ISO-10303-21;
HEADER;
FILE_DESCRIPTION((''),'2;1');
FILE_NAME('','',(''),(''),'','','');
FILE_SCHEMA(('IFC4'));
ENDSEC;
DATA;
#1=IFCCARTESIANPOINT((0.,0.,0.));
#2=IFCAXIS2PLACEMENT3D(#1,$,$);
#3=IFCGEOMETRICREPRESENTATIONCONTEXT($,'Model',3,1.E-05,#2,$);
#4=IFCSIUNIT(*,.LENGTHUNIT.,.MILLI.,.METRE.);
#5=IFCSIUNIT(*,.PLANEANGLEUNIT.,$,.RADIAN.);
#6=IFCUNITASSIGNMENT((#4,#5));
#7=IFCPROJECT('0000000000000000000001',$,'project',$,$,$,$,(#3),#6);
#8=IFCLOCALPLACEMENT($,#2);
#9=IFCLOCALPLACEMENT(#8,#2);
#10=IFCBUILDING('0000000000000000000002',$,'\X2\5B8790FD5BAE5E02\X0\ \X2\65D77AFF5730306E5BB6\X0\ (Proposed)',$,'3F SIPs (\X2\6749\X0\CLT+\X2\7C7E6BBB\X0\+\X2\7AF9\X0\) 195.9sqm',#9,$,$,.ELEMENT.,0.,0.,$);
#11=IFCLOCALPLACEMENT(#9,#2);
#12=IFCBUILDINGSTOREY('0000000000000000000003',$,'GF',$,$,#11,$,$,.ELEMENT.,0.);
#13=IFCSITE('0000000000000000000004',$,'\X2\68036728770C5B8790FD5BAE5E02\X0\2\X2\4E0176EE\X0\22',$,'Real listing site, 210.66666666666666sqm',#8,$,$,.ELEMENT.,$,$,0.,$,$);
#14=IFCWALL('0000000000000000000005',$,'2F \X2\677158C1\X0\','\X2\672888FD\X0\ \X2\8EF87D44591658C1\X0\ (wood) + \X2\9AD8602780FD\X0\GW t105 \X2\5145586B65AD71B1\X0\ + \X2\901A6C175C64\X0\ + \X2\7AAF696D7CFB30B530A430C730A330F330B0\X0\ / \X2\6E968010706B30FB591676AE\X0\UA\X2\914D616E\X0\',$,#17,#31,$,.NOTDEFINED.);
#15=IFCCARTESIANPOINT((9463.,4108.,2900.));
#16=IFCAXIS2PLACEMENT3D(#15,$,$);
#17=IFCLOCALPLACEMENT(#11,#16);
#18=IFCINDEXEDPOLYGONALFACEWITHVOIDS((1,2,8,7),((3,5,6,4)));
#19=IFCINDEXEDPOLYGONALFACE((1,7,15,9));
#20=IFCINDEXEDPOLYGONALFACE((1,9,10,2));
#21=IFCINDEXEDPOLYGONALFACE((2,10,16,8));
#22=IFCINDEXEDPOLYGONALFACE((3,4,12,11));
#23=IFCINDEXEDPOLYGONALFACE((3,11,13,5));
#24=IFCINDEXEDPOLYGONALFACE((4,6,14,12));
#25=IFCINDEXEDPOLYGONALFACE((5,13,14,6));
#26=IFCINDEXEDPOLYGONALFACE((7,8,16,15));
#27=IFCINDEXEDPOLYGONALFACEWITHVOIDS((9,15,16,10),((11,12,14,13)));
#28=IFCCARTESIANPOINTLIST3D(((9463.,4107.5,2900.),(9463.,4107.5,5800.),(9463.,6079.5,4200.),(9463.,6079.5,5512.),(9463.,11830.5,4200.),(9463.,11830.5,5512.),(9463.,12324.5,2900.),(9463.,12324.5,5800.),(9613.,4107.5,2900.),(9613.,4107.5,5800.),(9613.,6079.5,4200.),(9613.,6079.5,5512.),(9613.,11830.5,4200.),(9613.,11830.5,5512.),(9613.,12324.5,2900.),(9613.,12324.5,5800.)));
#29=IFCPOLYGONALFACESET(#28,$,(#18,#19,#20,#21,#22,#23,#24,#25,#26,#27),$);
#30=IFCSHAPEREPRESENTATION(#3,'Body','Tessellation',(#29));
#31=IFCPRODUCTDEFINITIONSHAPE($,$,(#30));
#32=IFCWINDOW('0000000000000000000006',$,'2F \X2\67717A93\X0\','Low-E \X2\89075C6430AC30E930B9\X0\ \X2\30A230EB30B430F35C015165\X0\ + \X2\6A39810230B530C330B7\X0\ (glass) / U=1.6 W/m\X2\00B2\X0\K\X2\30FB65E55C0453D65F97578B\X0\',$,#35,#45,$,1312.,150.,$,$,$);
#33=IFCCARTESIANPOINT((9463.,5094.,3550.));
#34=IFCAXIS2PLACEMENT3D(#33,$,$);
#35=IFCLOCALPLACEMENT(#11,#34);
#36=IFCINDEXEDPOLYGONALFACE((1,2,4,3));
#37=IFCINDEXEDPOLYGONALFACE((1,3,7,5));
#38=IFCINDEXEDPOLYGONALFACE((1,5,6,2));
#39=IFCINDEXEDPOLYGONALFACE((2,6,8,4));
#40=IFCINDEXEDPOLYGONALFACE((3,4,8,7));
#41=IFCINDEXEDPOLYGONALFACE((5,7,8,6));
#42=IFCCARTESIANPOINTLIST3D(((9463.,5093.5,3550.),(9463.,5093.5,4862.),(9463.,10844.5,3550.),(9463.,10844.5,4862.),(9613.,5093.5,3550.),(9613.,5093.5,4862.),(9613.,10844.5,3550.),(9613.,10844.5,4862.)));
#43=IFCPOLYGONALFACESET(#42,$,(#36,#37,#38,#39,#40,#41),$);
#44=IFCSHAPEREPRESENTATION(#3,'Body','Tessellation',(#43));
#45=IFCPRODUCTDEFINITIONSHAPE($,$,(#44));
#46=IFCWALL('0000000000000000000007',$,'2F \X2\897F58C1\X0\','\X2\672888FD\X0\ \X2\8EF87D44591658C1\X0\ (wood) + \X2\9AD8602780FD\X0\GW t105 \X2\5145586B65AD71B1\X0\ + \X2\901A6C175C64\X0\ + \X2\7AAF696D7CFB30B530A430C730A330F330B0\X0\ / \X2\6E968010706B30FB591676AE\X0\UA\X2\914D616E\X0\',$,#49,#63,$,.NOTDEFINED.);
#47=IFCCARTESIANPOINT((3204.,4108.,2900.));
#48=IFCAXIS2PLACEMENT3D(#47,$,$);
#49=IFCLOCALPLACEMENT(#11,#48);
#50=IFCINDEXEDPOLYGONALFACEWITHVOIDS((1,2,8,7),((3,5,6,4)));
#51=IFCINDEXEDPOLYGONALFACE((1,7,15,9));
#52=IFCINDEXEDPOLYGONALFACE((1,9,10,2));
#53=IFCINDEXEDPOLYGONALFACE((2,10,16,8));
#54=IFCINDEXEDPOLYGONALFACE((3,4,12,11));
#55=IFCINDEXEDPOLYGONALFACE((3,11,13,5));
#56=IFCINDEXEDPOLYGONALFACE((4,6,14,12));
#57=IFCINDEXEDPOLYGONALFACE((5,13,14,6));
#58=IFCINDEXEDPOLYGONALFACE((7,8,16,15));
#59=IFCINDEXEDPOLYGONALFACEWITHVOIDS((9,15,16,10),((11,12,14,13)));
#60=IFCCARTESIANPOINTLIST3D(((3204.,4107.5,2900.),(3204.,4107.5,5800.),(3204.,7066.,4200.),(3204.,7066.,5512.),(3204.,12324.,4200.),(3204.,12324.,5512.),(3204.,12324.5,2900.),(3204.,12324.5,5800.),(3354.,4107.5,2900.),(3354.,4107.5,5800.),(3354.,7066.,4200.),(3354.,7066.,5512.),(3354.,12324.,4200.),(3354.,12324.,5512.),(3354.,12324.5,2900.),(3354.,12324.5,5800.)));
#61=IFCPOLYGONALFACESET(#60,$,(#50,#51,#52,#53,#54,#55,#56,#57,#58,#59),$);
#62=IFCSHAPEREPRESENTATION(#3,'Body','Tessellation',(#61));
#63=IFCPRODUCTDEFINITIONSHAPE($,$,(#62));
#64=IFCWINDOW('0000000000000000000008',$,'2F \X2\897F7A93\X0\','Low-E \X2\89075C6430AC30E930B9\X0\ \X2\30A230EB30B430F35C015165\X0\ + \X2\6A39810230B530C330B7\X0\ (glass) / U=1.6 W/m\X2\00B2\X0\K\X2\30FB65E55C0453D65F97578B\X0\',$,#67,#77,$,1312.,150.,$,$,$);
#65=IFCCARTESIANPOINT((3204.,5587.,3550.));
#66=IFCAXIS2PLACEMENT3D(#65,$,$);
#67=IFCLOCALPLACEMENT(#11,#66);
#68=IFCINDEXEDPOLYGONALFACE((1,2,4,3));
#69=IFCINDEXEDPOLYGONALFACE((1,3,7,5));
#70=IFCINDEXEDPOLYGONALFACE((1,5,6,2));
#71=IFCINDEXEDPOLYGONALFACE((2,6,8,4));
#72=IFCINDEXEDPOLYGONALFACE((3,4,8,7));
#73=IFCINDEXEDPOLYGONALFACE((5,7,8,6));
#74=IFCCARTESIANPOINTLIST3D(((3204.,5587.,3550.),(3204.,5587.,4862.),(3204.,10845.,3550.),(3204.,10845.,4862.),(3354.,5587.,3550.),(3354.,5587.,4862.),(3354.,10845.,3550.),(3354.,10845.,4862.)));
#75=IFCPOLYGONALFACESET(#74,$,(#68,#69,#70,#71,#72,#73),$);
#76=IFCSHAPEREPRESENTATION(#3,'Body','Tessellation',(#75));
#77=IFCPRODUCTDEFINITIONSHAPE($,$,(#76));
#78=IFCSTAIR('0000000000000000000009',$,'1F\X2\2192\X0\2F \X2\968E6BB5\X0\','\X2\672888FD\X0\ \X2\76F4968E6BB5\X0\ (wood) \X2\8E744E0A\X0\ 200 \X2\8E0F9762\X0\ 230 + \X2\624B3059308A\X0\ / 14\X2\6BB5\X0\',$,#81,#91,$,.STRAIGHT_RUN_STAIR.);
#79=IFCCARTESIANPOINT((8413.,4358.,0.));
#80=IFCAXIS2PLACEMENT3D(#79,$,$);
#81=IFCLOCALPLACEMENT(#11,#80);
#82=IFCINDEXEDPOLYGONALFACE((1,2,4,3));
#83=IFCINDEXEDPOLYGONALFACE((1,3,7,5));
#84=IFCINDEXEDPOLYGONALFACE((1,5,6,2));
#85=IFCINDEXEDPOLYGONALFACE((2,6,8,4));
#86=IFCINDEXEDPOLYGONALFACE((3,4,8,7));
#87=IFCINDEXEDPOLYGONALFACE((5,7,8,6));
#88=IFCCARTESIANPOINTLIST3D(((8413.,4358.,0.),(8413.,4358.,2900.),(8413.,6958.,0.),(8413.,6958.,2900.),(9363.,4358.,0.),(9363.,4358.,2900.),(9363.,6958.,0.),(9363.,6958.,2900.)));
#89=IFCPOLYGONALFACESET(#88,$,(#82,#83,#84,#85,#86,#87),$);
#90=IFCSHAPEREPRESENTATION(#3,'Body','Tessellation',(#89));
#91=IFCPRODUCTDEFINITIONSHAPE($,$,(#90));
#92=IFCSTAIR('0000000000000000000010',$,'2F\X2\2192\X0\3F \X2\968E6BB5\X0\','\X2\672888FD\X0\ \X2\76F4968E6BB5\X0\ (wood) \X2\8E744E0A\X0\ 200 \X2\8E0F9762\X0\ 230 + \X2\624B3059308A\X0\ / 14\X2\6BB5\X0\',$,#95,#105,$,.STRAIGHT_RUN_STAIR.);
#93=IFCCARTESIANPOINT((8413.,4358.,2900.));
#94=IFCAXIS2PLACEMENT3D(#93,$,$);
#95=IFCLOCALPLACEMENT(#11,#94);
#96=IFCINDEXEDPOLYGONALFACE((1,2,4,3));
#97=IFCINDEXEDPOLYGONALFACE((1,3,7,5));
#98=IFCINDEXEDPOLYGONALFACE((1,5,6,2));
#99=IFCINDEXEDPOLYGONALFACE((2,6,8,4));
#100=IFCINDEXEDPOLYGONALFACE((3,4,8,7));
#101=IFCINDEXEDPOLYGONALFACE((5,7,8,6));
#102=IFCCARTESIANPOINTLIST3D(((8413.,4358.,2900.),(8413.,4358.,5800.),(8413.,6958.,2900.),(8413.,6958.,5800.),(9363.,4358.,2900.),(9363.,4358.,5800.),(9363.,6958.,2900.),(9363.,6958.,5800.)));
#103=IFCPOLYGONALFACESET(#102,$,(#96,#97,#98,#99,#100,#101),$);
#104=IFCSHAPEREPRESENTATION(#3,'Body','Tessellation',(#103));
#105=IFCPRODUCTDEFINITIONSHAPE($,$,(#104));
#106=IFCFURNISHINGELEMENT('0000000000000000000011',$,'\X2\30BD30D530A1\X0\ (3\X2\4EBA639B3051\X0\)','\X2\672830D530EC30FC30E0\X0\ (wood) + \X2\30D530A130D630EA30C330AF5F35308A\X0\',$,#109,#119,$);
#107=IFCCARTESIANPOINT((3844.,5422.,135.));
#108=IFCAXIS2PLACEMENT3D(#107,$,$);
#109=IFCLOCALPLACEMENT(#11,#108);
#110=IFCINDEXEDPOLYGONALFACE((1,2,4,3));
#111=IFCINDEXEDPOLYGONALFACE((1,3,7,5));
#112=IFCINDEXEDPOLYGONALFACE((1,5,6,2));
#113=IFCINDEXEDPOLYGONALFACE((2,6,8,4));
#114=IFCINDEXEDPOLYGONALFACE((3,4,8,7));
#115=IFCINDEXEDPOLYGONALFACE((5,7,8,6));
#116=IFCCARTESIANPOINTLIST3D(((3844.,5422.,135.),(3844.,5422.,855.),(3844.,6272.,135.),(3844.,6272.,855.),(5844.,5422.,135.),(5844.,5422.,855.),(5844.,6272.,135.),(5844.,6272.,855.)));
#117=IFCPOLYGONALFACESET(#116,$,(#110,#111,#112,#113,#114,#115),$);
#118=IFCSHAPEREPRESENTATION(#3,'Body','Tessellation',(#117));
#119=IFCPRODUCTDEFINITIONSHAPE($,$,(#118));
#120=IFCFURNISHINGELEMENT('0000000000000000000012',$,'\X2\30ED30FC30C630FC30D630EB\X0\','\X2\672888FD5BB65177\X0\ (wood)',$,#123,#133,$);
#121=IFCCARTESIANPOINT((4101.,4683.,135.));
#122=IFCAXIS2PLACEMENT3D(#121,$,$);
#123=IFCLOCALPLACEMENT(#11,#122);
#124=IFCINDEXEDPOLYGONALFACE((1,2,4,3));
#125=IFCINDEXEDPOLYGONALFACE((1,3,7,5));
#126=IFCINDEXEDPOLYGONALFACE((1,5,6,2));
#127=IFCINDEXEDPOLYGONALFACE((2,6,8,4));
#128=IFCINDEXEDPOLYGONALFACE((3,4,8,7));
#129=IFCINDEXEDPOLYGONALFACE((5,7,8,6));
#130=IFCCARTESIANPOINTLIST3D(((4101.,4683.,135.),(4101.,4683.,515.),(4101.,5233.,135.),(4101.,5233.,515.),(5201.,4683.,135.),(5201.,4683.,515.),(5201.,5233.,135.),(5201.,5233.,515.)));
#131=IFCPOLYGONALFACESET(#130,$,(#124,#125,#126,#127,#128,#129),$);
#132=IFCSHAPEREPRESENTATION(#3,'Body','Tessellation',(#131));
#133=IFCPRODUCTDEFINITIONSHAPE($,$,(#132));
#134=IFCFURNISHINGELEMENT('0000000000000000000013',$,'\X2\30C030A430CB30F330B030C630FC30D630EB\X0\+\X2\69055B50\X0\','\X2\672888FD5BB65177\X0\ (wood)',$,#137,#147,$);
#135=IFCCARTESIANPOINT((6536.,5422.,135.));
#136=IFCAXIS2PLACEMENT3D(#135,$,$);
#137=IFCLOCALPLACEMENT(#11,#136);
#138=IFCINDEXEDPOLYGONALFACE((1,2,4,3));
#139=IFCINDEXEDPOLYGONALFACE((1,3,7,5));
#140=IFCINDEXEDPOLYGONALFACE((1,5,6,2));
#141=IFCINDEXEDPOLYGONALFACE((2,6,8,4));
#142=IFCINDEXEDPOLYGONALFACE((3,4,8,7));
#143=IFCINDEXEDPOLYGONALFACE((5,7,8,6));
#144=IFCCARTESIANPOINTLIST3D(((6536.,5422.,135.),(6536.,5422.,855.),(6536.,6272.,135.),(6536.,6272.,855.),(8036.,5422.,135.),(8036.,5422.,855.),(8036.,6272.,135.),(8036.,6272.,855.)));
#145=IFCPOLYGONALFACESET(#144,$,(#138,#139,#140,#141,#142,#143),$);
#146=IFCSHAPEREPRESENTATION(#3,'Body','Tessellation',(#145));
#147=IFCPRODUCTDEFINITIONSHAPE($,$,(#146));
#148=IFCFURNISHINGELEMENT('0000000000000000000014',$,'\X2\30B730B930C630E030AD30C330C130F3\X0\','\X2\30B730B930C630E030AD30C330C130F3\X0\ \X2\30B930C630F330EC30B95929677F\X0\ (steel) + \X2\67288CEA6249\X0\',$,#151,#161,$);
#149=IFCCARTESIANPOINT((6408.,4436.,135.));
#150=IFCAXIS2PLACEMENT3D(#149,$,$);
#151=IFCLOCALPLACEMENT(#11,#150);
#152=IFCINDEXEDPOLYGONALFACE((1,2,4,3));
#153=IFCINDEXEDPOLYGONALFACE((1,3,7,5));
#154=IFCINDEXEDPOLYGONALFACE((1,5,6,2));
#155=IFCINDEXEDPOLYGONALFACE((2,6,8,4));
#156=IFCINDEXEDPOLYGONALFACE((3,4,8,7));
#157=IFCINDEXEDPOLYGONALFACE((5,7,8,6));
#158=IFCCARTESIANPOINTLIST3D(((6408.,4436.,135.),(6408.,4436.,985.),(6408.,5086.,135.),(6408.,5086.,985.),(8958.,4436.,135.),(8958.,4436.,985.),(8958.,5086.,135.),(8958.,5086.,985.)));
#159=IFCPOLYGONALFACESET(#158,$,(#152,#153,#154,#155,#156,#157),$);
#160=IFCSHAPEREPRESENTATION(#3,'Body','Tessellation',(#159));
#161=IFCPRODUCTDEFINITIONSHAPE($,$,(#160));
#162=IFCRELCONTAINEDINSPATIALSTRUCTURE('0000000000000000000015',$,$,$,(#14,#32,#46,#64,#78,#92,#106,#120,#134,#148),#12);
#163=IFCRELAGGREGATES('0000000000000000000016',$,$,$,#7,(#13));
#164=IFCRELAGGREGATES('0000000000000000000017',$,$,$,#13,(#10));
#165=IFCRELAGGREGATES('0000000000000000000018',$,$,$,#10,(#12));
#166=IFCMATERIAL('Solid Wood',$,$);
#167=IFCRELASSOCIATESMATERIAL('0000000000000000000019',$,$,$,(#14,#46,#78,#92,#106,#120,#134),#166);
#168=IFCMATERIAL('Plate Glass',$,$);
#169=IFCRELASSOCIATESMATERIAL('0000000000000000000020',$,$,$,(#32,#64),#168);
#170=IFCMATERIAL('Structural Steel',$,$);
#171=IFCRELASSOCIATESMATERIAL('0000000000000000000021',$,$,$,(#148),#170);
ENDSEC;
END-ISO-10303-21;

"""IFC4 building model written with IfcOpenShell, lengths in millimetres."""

from ifc_helpers import new_model, si_unit, frame, frame_2d, origin, place, context, project, spatial, rectangle, extrude, material, element, fill, save


model = new_model("IFC4")

# Units and contexts
model_context = context("Model", 3, precision=1e-05, world=origin())
ifc_project = project(units=[si_unit("LENGTHUNIT", "METRE", prefix="MILLI"), si_unit("PLANEANGLEUNIT", "RADIAN")], contexts=[model_context])

# Site, building, storey
site_placement = place(None, origin())
site = spatial("IfcSite", under=ifc_project, at=site_placement, Name="栃木県宇都宮市2丁目22", ObjectType="Real listing site, 210.66666666666666sqm", CompositionType="ELEMENT", RefElevation=0.0)
building_placement = place(site_placement, origin())
building = spatial("IfcBuilding", under=site, at=building_placement, Name="宇都宮市 旗竿地の家 (Proposed)", ObjectType="3F SIPs (杉CLT+籾殻+竹) 195.9sqm", CompositionType="ELEMENT", ElevationOfRefHeight=0.0, ElevationOfTerrain=0.0)
storey_placement = place(building_placement, origin())
storey = spatial("IfcBuildingStorey", under=building, at=storey_placement, Name="GF", CompositionType="ELEMENT", Elevation=0.0)

# Shared definitions
ifc_material_1 = material(Name="Solid Wood")

# Shared definitions
ifc_material_2 = material(Name="Plate Glass")

# Walls, openings, windows
wall_1_placement = place(storey_placement, frame((9463.0, 4108.0, 2900.0)))
wall_1 = element("IfcWall", 1, at=wall_1_placement, inside=storey, material=ifc_material_1, Name="2F 東壁", Description="木製 軸組外壁 (wood) + 高性能GW t105 充填断熱 + 通気層 + 窯業系サイディング / 準耐火・外皮UA配慮", PredefinedType="NOTDEFINED", context=model_context, shape_type="SweptSolid", body=[
    extrude(rectangle(XDim=150.0, YDim=8217.0, at=frame_2d((75.0, 4108.0))), frame((9463.0, 4108.0, 2900.0)), (0.0, 0.0, 1.0), 2900.0),
])
opening_1_placement = place(storey_placement, frame((9463.0, 5094.0, 3550.0)))
opening_1 = element("IfcOpeningElement", 2, at=opening_1_placement, cuts=wall_1, PredefinedType="NOTDEFINED", context=model_context, shape_type="SweptSolid", body=[
    extrude(rectangle(XDim=150.0, YDim=5751.0, at=frame_2d((75.0, 2875.0))), frame((9463.0, 5094.0, 3550.0)), (0.0, 0.0, 1.0), 1312.0),
])
window_1_placement = place(storey_placement, frame((9463.0, 5094.0, 3550.0)))
window_1 = element("IfcWindow", 3, at=window_1_placement, inside=storey, material=ifc_material_2, Name="2F 東窓", Description="Low-E 複層ガラス アルゴン封入 + 樹脂サッシ (glass) / U=1.6 W/m²K・日射取得型", OverallHeight=1312.0, OverallWidth=150.0, context=model_context, shape_type="SweptSolid", body=[
    extrude(rectangle(XDim=150.0, YDim=5751.0, at=frame_2d((75.0, 2875.0))), frame((9463.0, 5094.0, 3550.0)), (0.0, 0.0, 1.0), 1312.0),
])
fill(opening_1, window_1)
wall_2_placement = place(storey_placement, frame((3204.0, 4108.0, 2900.0)))
wall_2 = element("IfcWall", 4, at=wall_2_placement, inside=storey, material=ifc_material_1, Name="2F 西壁", Description="木製 軸組外壁 (wood) + 高性能GW t105 充填断熱 + 通気層 + 窯業系サイディング / 準耐火・外皮UA配慮", PredefinedType="NOTDEFINED", context=model_context, shape_type="SweptSolid", body=[
    extrude(rectangle(XDim=150.0, YDim=8217.0, at=frame_2d((75.0, 4108.0))), frame((3204.0, 4108.0, 2900.0)), (0.0, 0.0, 1.0), 2900.0),
])
opening_2_placement = place(storey_placement, frame((3204.0, 5587.0, 3550.0)))
opening_2 = element("IfcOpeningElement", 5, at=opening_2_placement, cuts=wall_2, PredefinedType="NOTDEFINED", context=model_context, shape_type="SweptSolid", body=[
    extrude(rectangle(XDim=150.0, YDim=5258.0, at=frame_2d((75.0, 2629.0))), frame((3204.0, 5587.0, 3550.0)), (0.0, 0.0, 1.0), 1312.0),
])
window_2_placement = place(storey_placement, frame((3204.0, 5587.0, 3550.0)))
window_2 = element("IfcWindow", 6, at=window_2_placement, inside=storey, material=ifc_material_2, Name="2F 西窓", Description="Low-E 複層ガラス アルゴン封入 + 樹脂サッシ (glass) / U=1.6 W/m²K・日射取得型", OverallHeight=1312.0, OverallWidth=150.0, context=model_context, shape_type="SweptSolid", body=[
    extrude(rectangle(XDim=150.0, YDim=5258.0, at=frame_2d((75.0, 2629.0))), frame((3204.0, 5587.0, 3550.0)), (0.0, 0.0, 1.0), 1312.0),
])
fill(opening_2, window_2)

# Stairs
stair_1_placement = place(storey_placement, frame((8413.0, 4358.0, 0.0)))
element("IfcStair", 7, at=stair_1_placement, inside=storey, material=ifc_material_1, Name="1F→2F 階段", Description="木製 直階段 (wood) 蹴上 200 踏面 230 + 手すり / 14段", PredefinedType="STRAIGHT_RUN_STAIR", context=model_context, shape_type="SweptSolid", body=[
    extrude(rectangle(XDim=950.0, YDim=2600.0, at=frame_2d((475.0, 1300.0))), frame((8413.0, 4358.0, 0.0)), (0.0, 0.0, 1.0), 2900.0),
])
stair_2_placement = place(storey_placement, frame((8413.0, 4358.0, 2900.0)))
element("IfcStair", 8, at=stair_2_placement, inside=storey, material=ifc_material_1, Name="2F→3F 階段", Description="木製 直階段 (wood) 蹴上 200 踏面 230 + 手すり / 14段", PredefinedType="STRAIGHT_RUN_STAIR", context=model_context, shape_type="SweptSolid", body=[
    extrude(rectangle(XDim=950.0, YDim=2600.0, at=frame_2d((475.0, 1300.0))), frame((8413.0, 4358.0, 2900.0)), (0.0, 0.0, 1.0), 2900.0),
])

# Furnishing elements
furnishing_1_placement = place(storey_placement, frame((3844.0, 5422.0, 135.0)))
element("IfcFurnishingElement", 9, at=furnishing_1_placement, inside=storey, material=ifc_material_1, Name="ソファ (3人掛け)", Description="木フレーム (wood) + ファブリック張り", context=model_context, shape_type="SweptSolid", body=[
    extrude(rectangle(XDim=2000.0, YDim=850.0, at=frame_2d((1000.0, 425.0))), frame((3844.0, 5422.0, 135.0)), (0.0, 0.0, 1.0), 720.0),
])
furnishing_2_placement = place(storey_placement, frame((4101.0, 4683.0, 135.0)))
element("IfcFurnishingElement", 10, at=furnishing_2_placement, inside=storey, material=ifc_material_1, Name="ローテーブル", Description="木製家具 (wood)", context=model_context, shape_type="SweptSolid", body=[
    extrude(rectangle(XDim=1100.0, YDim=550.0, at=frame_2d((550.0, 275.0))), frame((4101.0, 4683.0, 135.0)), (0.0, 0.0, 1.0), 380.0),
])
furnishing_3_placement = place(storey_placement, frame((6536.0, 5422.0, 135.0)))
element("IfcFurnishingElement", 11, at=furnishing_3_placement, inside=storey, material=ifc_material_1, Name="ダイニングテーブル+椅子", Description="木製家具 (wood)", context=model_context, shape_type="SweptSolid", body=[
    extrude(rectangle(XDim=1500.0, YDim=850.0, at=frame_2d((750.0, 425.0))), frame((6536.0, 5422.0, 135.0)), (0.0, 0.0, 1.0), 720.0),
])
ifc_material_3 = material(Name="Structural Steel")
furnishing_4_placement = place(storey_placement, frame((6408.0, 4436.0, 135.0)))
element("IfcFurnishingElement", 12, at=furnishing_4_placement, inside=storey, material=ifc_material_3, Name="システムキッチン", Description="システムキッチン ステンレス天板 (steel) + 木質扉", context=model_context, shape_type="SweptSolid", body=[
    extrude(rectangle(XDim=2550.0, YDim=650.0, at=frame_2d((1275.0, 325.0))), frame((6408.0, 4436.0, 135.0)), (0.0, 0.0, 1.0), 850.0),
])

save(model, "model.ifc")
